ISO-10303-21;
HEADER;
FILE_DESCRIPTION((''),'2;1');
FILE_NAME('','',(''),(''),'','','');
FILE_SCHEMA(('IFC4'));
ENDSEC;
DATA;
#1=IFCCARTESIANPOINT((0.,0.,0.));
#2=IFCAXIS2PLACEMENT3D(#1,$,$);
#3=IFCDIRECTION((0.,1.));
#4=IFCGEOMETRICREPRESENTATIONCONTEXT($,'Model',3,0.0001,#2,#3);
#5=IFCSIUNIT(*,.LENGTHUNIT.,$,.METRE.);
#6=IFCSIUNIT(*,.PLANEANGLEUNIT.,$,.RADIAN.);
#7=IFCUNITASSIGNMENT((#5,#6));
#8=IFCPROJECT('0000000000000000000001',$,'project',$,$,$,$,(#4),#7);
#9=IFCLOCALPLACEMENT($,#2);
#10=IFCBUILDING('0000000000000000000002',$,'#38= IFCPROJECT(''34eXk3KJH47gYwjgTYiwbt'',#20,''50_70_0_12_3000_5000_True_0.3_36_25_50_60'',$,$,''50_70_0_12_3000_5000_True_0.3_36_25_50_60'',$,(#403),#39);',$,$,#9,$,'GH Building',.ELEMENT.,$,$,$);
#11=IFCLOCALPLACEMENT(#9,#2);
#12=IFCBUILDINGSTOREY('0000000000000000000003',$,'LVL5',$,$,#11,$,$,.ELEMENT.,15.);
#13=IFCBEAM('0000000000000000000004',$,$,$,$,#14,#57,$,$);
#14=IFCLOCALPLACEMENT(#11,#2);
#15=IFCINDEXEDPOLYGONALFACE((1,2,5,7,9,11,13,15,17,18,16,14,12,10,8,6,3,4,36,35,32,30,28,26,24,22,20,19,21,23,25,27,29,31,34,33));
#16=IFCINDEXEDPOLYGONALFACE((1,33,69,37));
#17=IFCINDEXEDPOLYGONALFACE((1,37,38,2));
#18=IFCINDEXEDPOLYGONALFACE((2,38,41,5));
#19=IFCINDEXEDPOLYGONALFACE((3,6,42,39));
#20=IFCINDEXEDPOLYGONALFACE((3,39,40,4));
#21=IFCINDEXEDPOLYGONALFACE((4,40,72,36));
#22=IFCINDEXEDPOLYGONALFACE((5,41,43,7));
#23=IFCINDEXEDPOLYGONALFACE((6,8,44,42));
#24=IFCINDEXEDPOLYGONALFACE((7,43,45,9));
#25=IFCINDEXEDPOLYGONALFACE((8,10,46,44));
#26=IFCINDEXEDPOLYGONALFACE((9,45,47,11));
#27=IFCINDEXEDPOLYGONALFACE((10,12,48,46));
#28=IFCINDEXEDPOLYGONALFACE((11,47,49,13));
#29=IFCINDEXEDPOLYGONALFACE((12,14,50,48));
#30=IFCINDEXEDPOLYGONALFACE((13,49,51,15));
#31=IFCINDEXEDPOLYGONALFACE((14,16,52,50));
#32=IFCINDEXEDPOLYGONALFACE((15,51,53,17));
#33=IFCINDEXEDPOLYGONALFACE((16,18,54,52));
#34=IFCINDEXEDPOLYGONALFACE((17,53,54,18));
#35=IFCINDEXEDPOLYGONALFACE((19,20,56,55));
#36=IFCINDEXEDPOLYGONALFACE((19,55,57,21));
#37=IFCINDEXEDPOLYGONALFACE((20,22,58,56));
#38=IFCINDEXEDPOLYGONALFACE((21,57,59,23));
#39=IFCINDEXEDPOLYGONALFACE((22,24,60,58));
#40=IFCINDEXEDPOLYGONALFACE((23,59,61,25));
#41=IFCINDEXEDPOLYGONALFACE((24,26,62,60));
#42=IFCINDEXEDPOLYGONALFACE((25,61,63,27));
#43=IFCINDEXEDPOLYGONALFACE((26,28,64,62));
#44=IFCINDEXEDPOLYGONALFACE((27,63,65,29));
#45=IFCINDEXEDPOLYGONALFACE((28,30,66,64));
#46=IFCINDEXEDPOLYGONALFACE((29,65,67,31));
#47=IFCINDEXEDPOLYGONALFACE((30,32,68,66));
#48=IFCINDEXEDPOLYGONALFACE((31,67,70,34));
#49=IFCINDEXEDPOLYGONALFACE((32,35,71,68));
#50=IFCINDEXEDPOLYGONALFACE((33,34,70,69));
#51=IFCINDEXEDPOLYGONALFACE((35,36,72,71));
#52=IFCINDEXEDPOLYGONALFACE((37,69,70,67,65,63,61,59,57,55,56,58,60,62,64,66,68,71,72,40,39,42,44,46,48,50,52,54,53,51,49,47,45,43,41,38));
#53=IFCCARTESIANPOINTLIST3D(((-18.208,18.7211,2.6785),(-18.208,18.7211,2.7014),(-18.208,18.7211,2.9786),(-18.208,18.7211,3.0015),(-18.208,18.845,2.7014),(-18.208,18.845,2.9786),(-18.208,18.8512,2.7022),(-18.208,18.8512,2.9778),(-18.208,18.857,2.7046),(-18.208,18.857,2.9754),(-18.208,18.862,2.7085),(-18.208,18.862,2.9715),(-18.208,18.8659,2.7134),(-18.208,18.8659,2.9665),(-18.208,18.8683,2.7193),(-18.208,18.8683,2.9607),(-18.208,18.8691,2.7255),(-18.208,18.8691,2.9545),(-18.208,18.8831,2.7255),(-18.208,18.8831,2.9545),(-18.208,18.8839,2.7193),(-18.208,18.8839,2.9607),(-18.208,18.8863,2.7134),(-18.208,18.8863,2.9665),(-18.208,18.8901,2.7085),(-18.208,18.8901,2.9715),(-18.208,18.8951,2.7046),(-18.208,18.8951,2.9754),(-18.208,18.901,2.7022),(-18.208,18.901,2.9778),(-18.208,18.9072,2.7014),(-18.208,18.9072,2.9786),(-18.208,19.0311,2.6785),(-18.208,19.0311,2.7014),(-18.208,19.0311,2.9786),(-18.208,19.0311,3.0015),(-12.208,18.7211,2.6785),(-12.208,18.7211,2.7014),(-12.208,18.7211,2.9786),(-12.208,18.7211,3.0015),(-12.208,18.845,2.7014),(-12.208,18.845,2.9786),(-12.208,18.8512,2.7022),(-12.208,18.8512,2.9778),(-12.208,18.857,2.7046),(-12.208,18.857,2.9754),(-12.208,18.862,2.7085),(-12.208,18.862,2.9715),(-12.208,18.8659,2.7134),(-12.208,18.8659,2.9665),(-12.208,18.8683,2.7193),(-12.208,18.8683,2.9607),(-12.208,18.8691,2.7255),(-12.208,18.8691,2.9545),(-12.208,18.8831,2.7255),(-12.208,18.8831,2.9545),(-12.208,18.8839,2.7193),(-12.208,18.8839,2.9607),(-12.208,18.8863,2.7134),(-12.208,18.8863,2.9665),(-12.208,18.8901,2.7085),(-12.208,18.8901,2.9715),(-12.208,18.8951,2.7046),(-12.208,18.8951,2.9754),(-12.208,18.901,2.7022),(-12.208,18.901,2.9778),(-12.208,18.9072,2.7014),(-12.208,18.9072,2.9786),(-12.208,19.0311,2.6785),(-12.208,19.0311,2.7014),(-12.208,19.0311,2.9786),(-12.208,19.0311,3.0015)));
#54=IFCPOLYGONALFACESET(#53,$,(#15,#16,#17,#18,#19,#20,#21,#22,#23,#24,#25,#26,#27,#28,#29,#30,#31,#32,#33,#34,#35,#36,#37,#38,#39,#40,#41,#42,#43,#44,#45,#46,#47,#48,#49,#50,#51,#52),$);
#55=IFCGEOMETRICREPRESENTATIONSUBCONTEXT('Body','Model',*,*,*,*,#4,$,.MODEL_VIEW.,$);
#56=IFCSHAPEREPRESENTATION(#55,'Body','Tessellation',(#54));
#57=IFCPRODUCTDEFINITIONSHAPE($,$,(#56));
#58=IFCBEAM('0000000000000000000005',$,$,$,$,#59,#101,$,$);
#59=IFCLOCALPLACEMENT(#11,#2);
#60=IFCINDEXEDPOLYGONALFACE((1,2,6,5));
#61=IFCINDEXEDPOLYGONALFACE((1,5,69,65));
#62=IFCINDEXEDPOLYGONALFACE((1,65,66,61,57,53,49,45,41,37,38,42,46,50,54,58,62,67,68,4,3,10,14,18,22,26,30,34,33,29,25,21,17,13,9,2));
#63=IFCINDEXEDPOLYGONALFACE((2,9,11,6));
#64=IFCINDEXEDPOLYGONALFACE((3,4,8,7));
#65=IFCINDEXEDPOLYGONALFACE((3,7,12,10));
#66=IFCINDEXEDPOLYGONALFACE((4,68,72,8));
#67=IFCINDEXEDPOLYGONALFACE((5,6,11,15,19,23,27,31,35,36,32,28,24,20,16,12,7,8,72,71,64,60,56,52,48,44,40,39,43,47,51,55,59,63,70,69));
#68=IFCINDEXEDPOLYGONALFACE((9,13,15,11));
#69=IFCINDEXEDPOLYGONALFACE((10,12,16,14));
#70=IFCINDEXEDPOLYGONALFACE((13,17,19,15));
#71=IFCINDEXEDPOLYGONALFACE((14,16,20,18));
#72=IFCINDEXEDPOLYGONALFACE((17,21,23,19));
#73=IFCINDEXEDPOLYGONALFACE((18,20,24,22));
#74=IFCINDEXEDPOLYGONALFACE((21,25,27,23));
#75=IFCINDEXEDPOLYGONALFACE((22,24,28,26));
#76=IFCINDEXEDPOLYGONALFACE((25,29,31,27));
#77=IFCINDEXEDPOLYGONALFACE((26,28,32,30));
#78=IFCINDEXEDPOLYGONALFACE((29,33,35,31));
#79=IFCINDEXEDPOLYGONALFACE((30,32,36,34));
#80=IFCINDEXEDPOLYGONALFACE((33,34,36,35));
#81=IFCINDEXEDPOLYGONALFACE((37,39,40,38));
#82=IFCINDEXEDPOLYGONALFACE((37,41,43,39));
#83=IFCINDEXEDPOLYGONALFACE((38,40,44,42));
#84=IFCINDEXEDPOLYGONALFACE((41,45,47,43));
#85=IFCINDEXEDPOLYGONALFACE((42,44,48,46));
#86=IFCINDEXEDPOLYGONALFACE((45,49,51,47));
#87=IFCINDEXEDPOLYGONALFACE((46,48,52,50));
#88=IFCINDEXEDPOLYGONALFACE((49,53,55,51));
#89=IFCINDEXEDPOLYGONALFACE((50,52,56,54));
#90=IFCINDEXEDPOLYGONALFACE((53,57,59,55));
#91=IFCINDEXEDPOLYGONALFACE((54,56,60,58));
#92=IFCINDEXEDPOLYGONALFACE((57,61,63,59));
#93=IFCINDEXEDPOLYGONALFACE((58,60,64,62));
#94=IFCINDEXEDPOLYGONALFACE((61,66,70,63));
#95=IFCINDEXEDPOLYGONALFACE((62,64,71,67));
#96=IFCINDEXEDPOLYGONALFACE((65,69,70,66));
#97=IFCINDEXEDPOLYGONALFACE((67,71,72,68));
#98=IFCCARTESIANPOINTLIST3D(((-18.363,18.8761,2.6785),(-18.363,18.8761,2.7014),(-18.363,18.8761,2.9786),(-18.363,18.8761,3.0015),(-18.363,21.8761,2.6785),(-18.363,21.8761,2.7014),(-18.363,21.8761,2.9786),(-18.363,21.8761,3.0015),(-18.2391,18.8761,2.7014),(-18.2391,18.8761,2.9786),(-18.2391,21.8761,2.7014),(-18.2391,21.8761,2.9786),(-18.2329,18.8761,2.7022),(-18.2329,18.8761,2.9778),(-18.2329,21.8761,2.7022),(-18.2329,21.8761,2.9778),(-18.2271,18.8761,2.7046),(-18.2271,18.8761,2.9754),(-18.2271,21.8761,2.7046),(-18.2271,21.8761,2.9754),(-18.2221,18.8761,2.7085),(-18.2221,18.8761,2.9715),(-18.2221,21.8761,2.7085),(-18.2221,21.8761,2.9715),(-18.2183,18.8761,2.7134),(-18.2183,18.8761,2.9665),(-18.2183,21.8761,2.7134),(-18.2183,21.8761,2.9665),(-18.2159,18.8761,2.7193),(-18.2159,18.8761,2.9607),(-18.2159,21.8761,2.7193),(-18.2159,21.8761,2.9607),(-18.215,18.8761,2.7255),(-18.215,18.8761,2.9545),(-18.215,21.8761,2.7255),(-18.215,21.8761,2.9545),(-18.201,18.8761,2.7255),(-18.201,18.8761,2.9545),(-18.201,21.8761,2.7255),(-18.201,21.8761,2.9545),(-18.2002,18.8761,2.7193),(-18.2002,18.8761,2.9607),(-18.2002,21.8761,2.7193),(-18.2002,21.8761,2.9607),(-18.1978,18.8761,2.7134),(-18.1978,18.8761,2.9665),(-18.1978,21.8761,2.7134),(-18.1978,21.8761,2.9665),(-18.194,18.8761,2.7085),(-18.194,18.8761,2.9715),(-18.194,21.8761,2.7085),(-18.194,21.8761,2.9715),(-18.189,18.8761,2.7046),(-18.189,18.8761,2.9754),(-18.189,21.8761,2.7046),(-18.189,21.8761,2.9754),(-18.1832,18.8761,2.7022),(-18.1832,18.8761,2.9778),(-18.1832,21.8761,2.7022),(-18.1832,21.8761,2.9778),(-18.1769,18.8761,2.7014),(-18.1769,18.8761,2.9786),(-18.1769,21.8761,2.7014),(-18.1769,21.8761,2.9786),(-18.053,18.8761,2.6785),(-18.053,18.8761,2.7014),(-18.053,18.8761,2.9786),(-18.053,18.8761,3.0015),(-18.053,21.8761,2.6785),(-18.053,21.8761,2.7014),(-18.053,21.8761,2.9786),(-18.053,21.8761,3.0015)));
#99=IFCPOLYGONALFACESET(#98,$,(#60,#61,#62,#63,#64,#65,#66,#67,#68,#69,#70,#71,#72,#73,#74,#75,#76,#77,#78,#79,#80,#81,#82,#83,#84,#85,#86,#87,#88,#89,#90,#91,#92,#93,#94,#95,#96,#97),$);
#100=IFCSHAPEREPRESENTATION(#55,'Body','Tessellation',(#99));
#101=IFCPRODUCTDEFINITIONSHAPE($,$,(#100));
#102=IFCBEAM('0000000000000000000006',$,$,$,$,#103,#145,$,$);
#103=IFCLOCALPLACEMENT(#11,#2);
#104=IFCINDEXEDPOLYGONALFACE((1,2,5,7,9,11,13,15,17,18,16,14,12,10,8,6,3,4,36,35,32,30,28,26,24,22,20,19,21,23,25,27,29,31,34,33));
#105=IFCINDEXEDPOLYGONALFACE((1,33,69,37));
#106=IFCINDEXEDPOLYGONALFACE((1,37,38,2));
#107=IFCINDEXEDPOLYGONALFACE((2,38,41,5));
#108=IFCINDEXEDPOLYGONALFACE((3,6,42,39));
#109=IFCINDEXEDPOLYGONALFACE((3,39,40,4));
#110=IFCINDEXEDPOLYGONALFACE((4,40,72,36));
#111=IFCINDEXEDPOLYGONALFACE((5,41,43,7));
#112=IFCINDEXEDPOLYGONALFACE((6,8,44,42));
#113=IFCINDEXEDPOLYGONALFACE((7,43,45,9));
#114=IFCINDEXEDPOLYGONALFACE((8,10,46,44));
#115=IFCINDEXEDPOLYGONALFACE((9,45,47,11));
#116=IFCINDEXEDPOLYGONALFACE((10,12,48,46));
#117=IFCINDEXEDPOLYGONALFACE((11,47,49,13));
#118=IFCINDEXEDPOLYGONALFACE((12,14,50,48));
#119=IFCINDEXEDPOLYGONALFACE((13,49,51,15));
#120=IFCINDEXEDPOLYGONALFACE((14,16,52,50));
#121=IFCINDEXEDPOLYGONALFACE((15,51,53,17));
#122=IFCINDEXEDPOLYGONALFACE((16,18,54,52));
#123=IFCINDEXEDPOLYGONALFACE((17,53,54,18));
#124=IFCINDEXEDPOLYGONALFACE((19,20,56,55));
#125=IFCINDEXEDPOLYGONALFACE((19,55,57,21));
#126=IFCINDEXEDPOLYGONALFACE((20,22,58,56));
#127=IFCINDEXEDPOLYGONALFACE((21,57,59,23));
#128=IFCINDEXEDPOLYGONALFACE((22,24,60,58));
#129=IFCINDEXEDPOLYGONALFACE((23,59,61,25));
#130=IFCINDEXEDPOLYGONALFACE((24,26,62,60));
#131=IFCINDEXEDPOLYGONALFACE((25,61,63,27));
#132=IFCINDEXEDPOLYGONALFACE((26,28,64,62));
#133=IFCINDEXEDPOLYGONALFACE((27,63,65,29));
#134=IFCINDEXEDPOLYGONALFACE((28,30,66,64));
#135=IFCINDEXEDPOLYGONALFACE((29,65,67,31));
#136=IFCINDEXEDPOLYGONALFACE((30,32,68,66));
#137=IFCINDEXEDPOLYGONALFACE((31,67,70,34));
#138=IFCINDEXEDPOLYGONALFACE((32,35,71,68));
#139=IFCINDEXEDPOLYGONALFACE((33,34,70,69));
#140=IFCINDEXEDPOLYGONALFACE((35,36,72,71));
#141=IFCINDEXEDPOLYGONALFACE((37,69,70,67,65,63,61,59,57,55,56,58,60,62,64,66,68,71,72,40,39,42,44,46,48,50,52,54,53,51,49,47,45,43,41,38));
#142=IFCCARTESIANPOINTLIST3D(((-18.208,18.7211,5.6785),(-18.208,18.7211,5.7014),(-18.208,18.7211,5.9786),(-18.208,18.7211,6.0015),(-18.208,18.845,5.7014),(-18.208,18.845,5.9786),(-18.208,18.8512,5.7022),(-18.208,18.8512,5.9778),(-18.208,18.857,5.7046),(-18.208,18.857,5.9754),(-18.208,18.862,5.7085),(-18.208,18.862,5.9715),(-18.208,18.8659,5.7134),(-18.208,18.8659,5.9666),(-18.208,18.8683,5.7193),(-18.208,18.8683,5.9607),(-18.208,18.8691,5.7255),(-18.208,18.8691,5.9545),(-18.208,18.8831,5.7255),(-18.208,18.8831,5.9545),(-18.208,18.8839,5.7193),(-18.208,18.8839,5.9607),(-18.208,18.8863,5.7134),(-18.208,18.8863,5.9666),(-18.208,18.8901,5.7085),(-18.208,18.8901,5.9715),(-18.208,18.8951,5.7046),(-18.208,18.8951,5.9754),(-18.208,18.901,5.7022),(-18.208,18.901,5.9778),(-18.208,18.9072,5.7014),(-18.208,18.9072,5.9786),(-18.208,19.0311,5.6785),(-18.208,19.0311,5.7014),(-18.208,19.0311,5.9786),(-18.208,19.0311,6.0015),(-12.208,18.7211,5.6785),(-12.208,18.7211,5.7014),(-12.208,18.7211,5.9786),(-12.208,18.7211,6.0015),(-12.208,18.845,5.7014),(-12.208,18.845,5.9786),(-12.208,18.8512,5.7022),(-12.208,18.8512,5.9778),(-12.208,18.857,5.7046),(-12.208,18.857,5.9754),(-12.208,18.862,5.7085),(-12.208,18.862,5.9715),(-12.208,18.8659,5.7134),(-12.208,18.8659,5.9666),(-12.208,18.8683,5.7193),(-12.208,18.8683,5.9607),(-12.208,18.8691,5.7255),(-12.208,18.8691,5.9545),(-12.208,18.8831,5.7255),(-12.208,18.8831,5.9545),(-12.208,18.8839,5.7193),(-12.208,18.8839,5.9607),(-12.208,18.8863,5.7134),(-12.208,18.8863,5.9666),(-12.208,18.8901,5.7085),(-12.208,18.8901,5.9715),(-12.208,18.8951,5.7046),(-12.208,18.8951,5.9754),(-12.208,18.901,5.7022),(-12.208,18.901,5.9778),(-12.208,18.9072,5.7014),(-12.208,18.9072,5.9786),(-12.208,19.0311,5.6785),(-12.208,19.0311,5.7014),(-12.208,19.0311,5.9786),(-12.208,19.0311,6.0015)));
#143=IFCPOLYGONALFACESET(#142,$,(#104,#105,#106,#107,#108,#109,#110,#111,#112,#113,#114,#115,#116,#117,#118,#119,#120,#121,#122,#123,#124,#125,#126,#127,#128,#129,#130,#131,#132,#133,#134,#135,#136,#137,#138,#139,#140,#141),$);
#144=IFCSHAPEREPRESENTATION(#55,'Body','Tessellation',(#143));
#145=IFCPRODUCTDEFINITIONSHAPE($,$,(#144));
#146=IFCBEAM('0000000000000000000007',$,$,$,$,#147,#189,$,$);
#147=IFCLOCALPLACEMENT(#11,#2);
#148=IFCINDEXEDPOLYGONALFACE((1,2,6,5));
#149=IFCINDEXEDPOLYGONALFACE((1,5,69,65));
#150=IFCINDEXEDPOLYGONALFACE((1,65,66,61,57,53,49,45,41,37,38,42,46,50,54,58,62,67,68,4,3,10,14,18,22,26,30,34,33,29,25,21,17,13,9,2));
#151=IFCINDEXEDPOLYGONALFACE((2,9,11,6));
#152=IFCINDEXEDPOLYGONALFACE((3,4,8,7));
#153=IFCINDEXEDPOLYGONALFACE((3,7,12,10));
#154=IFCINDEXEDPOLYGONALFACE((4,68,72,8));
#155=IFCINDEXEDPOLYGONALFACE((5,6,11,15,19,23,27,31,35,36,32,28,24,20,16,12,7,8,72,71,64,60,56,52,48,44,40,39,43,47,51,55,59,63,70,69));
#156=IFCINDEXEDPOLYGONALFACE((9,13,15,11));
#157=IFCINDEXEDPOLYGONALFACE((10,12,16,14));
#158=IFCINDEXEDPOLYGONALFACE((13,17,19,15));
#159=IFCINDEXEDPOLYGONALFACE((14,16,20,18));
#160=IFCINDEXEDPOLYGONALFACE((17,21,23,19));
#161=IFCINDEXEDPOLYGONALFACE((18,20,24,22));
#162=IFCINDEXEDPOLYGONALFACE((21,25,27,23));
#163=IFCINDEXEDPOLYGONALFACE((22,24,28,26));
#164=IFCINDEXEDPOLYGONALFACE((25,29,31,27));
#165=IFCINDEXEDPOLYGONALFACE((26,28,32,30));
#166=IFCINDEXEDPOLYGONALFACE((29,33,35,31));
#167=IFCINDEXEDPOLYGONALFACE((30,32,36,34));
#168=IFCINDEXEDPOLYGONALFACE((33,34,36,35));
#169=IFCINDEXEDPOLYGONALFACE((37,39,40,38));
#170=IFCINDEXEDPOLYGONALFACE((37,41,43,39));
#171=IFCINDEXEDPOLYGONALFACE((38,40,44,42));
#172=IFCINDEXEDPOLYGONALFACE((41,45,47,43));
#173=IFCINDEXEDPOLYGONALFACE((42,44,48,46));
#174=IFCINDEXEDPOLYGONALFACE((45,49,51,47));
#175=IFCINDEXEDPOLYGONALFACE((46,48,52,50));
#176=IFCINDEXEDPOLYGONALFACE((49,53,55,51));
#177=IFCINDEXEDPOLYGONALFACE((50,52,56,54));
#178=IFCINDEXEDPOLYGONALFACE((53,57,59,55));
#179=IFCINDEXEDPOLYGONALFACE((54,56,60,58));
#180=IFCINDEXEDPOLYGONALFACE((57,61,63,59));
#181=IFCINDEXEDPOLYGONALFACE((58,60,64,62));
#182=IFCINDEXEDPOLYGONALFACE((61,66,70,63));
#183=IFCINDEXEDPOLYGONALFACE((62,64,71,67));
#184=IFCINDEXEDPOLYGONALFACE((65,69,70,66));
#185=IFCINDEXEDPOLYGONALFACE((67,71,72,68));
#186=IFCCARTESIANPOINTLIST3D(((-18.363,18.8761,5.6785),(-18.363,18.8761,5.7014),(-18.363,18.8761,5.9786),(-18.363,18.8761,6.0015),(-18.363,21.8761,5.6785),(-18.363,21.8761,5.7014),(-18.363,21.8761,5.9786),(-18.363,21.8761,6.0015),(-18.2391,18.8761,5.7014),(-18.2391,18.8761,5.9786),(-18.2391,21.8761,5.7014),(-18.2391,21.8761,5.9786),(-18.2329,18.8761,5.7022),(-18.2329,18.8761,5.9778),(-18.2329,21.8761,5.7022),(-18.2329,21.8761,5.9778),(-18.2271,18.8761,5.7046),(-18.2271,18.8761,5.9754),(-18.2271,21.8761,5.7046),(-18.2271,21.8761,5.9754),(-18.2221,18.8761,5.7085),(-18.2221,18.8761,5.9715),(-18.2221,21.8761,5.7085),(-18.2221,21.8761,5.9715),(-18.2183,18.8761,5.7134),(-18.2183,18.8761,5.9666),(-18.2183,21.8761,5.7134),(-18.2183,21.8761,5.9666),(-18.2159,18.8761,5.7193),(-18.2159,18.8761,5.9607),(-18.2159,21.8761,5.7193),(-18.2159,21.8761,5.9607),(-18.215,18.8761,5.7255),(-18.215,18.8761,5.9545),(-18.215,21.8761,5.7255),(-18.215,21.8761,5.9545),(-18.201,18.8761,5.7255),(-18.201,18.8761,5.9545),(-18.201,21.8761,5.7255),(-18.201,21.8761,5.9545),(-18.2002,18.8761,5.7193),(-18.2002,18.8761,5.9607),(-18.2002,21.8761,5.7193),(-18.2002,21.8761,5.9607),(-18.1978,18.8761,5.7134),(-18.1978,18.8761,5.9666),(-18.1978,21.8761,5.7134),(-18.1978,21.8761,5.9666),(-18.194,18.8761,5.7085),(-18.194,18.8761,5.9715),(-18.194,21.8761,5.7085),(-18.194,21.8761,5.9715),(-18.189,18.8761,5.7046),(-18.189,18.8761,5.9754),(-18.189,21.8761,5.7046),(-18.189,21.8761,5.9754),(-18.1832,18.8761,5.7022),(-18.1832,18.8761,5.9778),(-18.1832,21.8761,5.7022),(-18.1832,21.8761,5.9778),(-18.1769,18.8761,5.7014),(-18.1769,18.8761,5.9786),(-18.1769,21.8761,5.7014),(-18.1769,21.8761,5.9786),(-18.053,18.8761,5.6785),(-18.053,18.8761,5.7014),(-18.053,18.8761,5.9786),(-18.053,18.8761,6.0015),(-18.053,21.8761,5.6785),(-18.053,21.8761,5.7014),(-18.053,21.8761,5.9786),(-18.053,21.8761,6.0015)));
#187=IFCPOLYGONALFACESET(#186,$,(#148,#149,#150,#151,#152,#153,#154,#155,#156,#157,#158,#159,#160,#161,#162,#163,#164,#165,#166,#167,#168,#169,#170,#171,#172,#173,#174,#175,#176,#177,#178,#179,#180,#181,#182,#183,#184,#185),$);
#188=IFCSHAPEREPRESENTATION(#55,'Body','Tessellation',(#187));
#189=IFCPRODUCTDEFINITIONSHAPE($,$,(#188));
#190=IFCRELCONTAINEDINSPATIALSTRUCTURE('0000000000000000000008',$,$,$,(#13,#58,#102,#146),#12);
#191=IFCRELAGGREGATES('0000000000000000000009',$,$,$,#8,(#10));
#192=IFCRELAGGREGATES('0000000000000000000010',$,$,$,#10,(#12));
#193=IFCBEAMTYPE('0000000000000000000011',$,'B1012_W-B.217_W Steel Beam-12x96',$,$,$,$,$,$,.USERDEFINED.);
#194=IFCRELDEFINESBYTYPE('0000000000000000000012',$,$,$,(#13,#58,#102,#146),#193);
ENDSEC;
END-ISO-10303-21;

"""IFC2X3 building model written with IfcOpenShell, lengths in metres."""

from ifc_helpers import new_model, si_unit, direction, frame, origin, origin_2d, place, context, subcontext, project, spatial, i_section, extrude, type_object, element, save


model = new_model("IFC2X3")

# Units and contexts
model_context = context("Model", 3, precision=0.0001, world=origin(), true_north=direction((0.0, 1.0)))
body_context = subcontext(model_context, "Body", "Model", "MODEL_VIEW")
ifc_project = project(units=[si_unit("LENGTHUNIT", "METRE"), si_unit("PLANEANGLEUNIT", "RADIAN")], contexts=[model_context])

# Building, storey
building_placement = place(None, origin())
building = spatial("IfcBuilding", under=ifc_project, at=building_placement, Name="#38= IFCPROJECT('34eXk3KJH47gYwjgTYiwbt',#20,'50_70_0_12_3000_5000_True_0.3_36_25_50_60',$,$,'50_70_0_12_3000_5000_True_0.3_36_25_50_60',$,(#403),#39);", LongName="GH Building", CompositionType="ELEMENT")
storey_placement = place(building_placement, origin())
storey = spatial("IfcBuildingStorey", under=building, at=storey_placement, Name="LVL5", CompositionType="ELEMENT", Elevation=15.0)

# Beams
beam_type = type_object("IfcBeamType", Name="B1012_W-B.217_W Steel Beam-12x96", PredefinedType="USERDEFINED")
beam_1_placement = place(storey_placement, frame((-18.208, 18.8761, 2.84), z_axis=(1.0, 0.0, 0.0), x_axis=(0.0, 1.0, 0.0)))
element("IfcBeam", 1, at=beam_1_placement, inside=storey, type_object=beam_type, context=body_context, shape_type="SweptSolid", body=[
    extrude(i_section(OverallWidth=0.31, OverallDepth=0.323, WebThickness=0.014, FlangeThickness=0.0229, FilletRadius=0.0241, at=origin_2d()), origin(), (0.0, 0.0, 1.0), 6.0),
])
beam_2_placement = place(storey_placement, frame((-18.208, 18.8761, 2.84), z_axis=(0.0, 1.0, 0.0), x_axis=(-1.0, 0.0, 0.0)))
element("IfcBeam", 2, at=beam_2_placement, inside=storey, type_object=beam_type, context=body_context, shape_type="SweptSolid", body=[
    extrude(i_section(OverallWidth=0.31, OverallDepth=0.323, WebThickness=0.014, FlangeThickness=0.0229, FilletRadius=0.0241, at=origin_2d()), origin(), (0.0, 0.0, 1.0), 3.0),
])
beam_3_placement = place(storey_placement, frame((-18.208, 18.8761, 5.84), z_axis=(1.0, 0.0, 0.0), x_axis=(0.0, 1.0, 0.0)))
element("IfcBeam", 3, at=beam_3_placement, inside=storey, type_object=beam_type, context=body_context, shape_type="SweptSolid", body=[
    extrude(i_section(OverallWidth=0.31, OverallDepth=0.323, WebThickness=0.014, FlangeThickness=0.0229, FilletRadius=0.0241, at=origin_2d()), origin(), (0.0, 0.0, 1.0), 6.0),
])
beam_4_placement = place(storey_placement, frame((-18.208, 18.8761, 5.84), z_axis=(0.0, 1.0, 0.0), x_axis=(-1.0, 0.0, 0.0)))
element("IfcBeam", 4, at=beam_4_placement, inside=storey, type_object=beam_type, context=body_context, shape_type="SweptSolid", body=[
    extrude(i_section(OverallWidth=0.31, OverallDepth=0.323, WebThickness=0.014, FlangeThickness=0.0229, FilletRadius=0.0241, at=origin_2d()), origin(), (0.0, 0.0, 1.0), 3.0),
])

save(model, "model.ifc")
